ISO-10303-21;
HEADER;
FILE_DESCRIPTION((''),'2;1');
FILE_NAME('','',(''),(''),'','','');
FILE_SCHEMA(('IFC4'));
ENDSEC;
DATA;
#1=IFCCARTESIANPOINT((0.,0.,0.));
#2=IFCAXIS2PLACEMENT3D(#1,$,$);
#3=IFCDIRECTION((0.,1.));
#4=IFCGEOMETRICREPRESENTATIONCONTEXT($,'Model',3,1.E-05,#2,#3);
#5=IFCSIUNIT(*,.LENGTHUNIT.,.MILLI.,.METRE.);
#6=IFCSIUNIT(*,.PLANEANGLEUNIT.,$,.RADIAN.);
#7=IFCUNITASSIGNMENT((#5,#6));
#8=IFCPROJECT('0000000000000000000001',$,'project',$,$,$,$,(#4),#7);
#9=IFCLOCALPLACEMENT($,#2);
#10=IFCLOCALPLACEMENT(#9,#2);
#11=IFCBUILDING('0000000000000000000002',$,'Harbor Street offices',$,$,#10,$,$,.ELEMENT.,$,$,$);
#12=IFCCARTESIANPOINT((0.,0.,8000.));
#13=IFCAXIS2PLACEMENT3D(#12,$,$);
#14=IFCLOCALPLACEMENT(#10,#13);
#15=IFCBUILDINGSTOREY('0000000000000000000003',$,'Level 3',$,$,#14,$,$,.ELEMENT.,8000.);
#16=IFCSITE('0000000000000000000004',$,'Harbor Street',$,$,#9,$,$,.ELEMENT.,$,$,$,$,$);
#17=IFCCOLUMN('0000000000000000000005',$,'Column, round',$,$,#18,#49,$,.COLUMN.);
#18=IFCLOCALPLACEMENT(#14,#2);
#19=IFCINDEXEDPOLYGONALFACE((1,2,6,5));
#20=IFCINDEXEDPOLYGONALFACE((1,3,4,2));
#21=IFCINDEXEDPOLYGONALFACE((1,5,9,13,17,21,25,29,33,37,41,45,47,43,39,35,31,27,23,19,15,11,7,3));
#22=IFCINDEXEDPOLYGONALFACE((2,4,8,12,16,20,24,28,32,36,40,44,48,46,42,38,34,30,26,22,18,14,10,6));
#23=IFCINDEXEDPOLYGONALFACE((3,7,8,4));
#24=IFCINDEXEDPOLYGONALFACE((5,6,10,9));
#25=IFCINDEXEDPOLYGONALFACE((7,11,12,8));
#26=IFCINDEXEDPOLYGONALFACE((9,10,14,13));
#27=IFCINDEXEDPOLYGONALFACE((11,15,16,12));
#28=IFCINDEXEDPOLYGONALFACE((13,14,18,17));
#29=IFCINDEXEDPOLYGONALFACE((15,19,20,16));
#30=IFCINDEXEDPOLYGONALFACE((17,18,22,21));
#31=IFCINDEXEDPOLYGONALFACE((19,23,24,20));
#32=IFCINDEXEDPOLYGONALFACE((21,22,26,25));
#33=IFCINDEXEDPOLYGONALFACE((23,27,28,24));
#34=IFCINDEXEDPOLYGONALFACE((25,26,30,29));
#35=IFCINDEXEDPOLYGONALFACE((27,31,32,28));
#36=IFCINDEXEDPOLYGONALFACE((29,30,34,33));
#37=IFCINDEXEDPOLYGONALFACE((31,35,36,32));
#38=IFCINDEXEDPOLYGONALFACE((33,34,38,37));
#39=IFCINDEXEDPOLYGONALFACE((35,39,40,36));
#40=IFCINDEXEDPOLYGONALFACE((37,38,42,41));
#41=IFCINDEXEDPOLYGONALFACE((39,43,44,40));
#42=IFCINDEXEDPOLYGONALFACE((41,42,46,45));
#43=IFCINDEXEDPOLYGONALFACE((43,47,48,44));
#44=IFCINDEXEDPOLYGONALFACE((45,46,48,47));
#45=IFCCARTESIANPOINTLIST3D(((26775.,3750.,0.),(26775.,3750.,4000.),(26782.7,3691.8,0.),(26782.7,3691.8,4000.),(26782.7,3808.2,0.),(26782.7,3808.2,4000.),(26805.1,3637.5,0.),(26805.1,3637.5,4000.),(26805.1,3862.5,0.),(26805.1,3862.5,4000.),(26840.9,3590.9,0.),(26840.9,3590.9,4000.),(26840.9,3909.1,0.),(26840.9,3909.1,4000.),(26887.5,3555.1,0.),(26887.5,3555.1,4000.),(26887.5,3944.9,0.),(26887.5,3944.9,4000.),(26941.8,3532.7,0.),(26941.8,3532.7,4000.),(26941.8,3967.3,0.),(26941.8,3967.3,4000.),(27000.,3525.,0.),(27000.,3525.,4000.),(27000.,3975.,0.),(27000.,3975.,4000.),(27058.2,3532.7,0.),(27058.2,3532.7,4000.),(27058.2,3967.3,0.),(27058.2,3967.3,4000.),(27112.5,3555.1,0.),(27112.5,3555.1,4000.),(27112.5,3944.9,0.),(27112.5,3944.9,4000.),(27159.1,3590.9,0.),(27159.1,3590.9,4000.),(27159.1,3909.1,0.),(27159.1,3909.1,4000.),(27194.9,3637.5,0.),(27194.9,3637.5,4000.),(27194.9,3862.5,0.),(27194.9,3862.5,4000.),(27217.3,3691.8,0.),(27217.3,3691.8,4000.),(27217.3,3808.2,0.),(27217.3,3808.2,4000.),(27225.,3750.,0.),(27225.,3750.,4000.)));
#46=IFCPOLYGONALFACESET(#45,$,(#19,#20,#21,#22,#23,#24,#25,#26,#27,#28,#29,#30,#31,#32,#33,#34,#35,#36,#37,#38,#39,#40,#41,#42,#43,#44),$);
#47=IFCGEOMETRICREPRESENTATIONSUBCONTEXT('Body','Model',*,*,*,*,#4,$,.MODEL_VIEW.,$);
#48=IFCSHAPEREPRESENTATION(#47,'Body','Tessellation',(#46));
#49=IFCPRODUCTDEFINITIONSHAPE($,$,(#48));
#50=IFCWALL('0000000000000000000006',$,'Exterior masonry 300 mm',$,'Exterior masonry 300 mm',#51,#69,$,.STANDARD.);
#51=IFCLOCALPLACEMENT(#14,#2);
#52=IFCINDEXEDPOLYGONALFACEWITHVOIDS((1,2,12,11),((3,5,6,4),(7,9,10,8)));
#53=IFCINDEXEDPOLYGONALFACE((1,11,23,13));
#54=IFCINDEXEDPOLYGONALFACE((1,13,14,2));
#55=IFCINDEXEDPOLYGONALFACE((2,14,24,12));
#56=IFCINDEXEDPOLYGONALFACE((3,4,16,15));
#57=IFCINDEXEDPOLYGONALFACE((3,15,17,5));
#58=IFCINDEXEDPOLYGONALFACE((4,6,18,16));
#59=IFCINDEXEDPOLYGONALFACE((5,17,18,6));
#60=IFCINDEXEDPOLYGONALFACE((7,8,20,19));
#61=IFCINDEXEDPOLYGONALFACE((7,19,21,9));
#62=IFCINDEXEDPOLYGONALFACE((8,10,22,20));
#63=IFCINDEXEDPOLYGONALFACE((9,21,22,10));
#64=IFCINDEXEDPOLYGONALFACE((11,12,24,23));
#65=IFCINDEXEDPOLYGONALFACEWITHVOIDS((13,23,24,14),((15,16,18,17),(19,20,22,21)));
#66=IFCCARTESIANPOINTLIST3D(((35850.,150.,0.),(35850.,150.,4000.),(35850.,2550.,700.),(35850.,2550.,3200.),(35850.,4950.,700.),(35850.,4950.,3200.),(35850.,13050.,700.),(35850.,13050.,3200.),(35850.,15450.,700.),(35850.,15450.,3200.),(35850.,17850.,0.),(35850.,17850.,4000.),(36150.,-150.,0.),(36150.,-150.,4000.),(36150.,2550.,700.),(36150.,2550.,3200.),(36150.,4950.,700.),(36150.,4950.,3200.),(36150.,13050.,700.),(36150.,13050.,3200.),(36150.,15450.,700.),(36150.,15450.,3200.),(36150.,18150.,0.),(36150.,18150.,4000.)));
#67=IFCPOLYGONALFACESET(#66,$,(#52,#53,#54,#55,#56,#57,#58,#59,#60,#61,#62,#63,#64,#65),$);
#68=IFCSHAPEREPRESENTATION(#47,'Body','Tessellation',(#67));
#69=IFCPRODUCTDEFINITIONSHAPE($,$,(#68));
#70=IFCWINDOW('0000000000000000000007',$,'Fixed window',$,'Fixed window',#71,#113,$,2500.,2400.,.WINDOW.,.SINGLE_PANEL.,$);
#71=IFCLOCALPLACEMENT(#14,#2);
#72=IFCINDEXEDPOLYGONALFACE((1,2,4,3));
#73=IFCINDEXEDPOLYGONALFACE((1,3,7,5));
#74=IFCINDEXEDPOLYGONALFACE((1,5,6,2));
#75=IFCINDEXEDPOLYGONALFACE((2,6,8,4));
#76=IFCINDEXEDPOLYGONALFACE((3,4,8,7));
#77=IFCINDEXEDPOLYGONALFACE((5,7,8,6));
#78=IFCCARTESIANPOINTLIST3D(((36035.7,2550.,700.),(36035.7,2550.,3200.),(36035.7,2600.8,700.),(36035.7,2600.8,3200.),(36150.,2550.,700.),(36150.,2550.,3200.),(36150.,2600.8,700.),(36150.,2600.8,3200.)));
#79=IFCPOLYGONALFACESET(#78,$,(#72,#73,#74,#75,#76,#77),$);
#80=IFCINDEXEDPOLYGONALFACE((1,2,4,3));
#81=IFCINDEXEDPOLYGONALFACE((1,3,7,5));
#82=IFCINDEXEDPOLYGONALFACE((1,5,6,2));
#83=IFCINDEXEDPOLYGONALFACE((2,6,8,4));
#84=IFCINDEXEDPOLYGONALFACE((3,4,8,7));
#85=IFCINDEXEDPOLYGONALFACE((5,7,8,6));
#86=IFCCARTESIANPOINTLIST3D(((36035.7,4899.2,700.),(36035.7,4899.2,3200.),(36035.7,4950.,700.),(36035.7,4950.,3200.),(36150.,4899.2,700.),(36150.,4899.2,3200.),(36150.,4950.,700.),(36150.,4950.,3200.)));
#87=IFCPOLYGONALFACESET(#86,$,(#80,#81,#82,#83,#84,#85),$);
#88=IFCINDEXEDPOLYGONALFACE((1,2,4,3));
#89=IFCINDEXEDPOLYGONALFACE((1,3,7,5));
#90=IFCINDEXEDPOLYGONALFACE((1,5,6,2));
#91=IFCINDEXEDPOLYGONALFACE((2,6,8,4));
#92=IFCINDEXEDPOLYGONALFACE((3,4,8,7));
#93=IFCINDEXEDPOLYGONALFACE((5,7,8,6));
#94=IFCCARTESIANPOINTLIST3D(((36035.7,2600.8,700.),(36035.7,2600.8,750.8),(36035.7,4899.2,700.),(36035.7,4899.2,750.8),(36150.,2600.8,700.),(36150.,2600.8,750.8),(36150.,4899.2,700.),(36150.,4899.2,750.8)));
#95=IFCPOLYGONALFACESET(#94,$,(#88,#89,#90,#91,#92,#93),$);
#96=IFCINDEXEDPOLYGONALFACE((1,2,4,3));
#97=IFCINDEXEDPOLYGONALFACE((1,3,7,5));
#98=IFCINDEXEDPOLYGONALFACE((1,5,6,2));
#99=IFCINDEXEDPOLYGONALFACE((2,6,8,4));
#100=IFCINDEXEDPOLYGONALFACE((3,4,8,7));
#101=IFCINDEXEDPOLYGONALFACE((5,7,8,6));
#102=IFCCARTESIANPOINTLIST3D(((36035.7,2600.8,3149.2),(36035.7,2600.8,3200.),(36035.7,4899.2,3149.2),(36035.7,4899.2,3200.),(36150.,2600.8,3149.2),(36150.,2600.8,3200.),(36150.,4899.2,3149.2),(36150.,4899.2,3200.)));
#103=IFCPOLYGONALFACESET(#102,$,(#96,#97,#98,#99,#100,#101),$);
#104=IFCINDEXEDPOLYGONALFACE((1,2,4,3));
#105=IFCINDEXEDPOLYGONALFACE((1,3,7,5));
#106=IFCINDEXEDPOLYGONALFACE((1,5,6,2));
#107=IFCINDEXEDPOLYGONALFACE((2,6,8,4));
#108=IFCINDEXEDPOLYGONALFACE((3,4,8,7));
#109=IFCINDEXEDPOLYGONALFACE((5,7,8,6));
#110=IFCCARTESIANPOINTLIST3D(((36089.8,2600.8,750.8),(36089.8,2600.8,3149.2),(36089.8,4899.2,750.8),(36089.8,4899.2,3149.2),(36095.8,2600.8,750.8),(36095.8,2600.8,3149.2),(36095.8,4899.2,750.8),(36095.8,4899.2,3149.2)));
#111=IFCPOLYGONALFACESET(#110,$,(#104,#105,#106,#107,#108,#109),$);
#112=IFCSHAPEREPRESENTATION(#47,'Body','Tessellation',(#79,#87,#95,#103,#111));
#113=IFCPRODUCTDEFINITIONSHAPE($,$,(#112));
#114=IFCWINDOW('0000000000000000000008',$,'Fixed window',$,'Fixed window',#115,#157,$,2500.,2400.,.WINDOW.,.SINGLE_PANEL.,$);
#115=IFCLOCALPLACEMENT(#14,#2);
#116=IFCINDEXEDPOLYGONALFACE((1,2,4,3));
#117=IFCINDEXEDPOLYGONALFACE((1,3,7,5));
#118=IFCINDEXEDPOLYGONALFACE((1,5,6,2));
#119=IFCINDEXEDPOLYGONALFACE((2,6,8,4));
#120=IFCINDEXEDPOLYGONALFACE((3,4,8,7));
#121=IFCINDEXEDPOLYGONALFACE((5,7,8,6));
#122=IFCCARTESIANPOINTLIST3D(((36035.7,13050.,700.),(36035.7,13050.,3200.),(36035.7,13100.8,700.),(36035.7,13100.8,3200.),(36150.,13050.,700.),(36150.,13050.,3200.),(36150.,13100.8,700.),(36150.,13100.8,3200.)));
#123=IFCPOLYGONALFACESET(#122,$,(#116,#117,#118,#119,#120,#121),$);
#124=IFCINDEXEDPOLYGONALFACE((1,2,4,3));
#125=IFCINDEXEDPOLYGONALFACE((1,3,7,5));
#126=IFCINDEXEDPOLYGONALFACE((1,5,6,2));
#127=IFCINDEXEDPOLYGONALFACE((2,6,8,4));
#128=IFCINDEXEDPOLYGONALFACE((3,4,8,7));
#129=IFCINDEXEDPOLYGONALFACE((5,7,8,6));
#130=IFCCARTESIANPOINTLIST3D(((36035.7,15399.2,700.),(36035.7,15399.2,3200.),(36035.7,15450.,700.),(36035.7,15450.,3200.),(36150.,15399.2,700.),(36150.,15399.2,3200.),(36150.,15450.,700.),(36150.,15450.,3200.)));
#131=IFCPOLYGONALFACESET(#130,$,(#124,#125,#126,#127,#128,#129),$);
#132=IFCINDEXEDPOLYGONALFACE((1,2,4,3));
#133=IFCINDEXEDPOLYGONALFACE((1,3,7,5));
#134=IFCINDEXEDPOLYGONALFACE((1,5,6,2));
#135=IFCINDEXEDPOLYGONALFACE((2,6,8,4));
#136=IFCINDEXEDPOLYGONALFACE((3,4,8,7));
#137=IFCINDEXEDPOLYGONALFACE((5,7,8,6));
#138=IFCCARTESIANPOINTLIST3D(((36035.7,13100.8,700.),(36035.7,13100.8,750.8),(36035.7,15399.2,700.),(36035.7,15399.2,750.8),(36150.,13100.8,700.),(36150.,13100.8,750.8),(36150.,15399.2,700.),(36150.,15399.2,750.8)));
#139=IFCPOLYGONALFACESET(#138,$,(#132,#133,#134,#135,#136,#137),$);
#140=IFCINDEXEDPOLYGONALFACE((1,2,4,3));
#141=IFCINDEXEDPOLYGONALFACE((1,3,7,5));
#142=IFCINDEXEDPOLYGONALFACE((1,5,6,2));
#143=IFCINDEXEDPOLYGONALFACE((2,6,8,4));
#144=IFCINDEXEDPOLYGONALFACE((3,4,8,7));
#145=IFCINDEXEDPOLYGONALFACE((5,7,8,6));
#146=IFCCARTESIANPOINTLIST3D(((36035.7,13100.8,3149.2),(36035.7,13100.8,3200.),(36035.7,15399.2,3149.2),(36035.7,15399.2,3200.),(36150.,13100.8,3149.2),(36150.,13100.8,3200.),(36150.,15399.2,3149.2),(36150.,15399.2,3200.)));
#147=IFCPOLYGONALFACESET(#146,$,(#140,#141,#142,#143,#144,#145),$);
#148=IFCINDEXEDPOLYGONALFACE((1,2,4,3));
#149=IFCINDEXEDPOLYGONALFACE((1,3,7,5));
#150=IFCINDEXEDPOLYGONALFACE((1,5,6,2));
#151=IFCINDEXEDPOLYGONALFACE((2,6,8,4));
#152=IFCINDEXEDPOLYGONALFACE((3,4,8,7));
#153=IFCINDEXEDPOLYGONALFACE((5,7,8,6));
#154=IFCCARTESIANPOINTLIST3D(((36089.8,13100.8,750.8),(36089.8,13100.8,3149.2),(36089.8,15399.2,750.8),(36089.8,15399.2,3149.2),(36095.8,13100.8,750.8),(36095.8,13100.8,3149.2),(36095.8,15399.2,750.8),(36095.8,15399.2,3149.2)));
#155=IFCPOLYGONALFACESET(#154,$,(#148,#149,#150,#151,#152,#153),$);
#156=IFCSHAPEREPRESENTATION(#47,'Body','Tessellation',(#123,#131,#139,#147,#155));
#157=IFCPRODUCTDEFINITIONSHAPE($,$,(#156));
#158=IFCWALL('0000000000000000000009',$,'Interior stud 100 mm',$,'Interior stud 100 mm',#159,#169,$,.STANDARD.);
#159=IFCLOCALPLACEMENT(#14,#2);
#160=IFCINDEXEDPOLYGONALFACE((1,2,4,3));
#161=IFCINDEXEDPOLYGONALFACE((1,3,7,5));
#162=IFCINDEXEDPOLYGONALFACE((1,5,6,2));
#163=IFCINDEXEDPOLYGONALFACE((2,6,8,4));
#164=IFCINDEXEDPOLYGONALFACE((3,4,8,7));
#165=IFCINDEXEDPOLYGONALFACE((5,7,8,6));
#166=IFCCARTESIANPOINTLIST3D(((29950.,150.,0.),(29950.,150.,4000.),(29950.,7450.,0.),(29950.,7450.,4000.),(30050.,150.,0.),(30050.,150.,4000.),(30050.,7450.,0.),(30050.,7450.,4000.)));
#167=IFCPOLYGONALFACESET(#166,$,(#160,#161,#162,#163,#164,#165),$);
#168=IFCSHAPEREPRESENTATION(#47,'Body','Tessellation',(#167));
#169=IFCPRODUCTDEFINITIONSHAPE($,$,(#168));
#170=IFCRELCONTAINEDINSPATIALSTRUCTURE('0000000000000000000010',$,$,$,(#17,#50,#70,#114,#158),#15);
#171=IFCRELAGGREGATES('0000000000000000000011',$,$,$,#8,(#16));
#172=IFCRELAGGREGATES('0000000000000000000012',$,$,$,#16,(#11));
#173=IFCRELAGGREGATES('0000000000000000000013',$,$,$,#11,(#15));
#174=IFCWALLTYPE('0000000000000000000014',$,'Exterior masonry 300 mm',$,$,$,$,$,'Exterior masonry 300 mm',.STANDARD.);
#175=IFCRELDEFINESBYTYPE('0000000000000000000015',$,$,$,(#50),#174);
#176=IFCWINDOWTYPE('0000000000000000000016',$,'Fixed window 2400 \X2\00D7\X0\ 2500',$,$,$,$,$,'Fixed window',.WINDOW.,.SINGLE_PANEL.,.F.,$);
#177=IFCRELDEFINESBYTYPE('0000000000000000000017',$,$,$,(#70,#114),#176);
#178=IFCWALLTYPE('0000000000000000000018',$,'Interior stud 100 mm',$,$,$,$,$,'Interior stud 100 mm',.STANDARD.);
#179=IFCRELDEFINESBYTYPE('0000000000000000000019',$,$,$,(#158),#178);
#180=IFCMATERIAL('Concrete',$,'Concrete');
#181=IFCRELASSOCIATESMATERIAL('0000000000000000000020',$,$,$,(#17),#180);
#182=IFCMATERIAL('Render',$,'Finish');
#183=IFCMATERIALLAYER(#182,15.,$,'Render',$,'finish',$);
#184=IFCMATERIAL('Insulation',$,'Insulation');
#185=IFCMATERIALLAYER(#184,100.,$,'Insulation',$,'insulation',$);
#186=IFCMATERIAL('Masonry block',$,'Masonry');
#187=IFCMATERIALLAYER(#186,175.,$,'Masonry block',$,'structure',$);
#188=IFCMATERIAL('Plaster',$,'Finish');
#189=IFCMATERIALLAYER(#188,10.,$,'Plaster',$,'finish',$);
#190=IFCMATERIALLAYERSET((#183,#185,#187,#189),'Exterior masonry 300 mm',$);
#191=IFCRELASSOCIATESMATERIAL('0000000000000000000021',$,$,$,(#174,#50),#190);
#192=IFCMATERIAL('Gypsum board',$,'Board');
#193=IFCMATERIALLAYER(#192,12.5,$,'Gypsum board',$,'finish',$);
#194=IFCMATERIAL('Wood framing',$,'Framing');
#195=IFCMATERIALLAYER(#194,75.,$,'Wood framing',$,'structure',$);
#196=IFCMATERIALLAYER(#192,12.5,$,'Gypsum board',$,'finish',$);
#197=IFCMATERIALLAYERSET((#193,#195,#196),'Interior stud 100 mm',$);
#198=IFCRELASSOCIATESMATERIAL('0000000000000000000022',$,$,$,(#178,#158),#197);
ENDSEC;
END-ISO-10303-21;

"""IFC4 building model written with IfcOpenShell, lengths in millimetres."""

from ifc_helpers import new_model, si_unit, direction, frame, origin, origin_with_axes, origin_2d, place, context, subcontext, project, spatial, polyline, circle, outline, extrude, material, layer, layer_set, layer_usage, type_object, element, fill, save


model = new_model("IFC4")

# Units and contexts
model_context = context("Model", 3, precision=1e-05, world=origin(), true_north=direction((0.0, 1.0)))
body_context = subcontext(model_context, "Body", "Model", "MODEL_VIEW")
ifc_project = project(units=[si_unit("LENGTHUNIT", "METRE", prefix="MILLI"), si_unit("PLANEANGLEUNIT", "RADIAN")], contexts=[model_context])

# Site, building, storey
site_placement = place(None, origin())
site = spatial("IfcSite", under=ifc_project, at=site_placement, Name="Harbor Street", CompositionType="ELEMENT")
building_placement = place(site_placement, origin())
building = spatial("IfcBuilding", under=site, at=building_placement, Name="Harbor Street offices", CompositionType="ELEMENT")
storey_placement = place(building_placement, frame((0.0, 0.0, 8000.0)))
storey = spatial("IfcBuildingStorey", under=building, at=storey_placement, Name="Level 3", CompositionType="ELEMENT", Elevation=8000.0)

# Column
ifc_material_1 = material(Name="Concrete", Category="Concrete")
column_placement = place(storey_placement, frame((27000.0, 3750.0, 0.0), z_axis=(0.0, 0.0, 1.0), x_axis=(1.0, 0.0, 0.0)))
element("IfcColumn", 1, at=column_placement, inside=storey, material=ifc_material_1, Name="Column, round", PredefinedType="COLUMN", context=body_context, shape_type="SweptSolid", body=[
    extrude(circle(Radius=225.0, at=origin_2d()), origin(), (0.0, 0.0, 1.0), 4000.0),
])

# Wall, openings, windows
ifc_material_2 = material(Name="Render", Category="Finish")
ifc_layer_1 = layer(ifc_material_2, 15.0, Name="Render", Category="finish")
ifc_material_3 = material(Name="Insulation", Category="Insulation")
ifc_layer_2 = layer(ifc_material_3, 100.0, Name="Insulation", Category="insulation")
ifc_material_4 = material(Name="Masonry block", Category="Masonry")
ifc_layer_3 = layer(ifc_material_4, 175.0, Name="Masonry block", Category="structure")
ifc_material_5 = material(Name="Plaster", Category="Finish")
ifc_layer_4 = layer(ifc_material_5, 10.0, Name="Plaster", Category="finish")
ifc_layer_set_1 = layer_set([ifc_layer_1, ifc_layer_2, ifc_layer_3, ifc_layer_4], Name="Exterior masonry 300 mm")
ifc_layer_usage_1 = layer_usage(ifc_layer_set_1, "AXIS2", "POSITIVE", -150.0)
wall_type_1 = type_object("IfcWallType", Name="Exterior masonry 300 mm", ElementType="Exterior masonry 300 mm", PredefinedType="STANDARD", material=ifc_layer_set_1)
wall_1_placement = place(storey_placement, frame((36000.0, 0.0, 0.0), z_axis=(0.0, 0.0, 1.0), x_axis=(0.0, 1.0, 0.0)))
wall_1 = element("IfcWall", 2, at=wall_1_placement, inside=storey, type_object=wall_type_1, material=ifc_layer_usage_1, Name="Exterior masonry 300 mm", ObjectType="Exterior masonry 300 mm", PredefinedType="STANDARD", context=body_context, shape_type="SweptSolid", body=[
    extrude(outline(polyline([(-150.0, -150.0), (18150.0, -150.0), (17850.0, 150.0), (150.0, 150.0), (-150.0, -150.0)])), origin(), (0.0, 0.0, 1.0), 4000.0),
])
opening_1_placement = place(wall_1_placement, frame((2550.0, 0.0, 700.0), z_axis=(0.0, 0.0, 1.0), x_axis=(1.0, 0.0, 0.0)))
opening_1 = element("IfcOpeningElement", 3, at=opening_1_placement, cuts=wall_1, PredefinedType="OPENING", context=body_context, shape_type="SweptSolid", body=[
    extrude(outline(polyline([(0.0, -160.0), (2400.0, -160.0), (2400.0, 160.0), (0.0, 160.0), (0.0, -160.0)])), origin(), (0.0, 0.0, 1.0), 2500.0),
])
opening_2_placement = place(wall_1_placement, frame((13050.0, 0.0, 700.0), z_axis=(0.0, 0.0, 1.0), x_axis=(1.0, 0.0, 0.0)))
opening_2 = element("IfcOpeningElement", 4, at=opening_2_placement, cuts=wall_1, PredefinedType="OPENING", context=body_context, shape_type="SweptSolid", body=[
    extrude(outline(polyline([(0.0, -160.0), (2400.0, -160.0), (2400.0, 160.0), (0.0, 160.0), (0.0, -160.0)])), origin(), (0.0, 0.0, 1.0), 2500.0),
])
window_type = type_object("IfcWindowType", Name="Fixed window 2400 × 2500", ElementType="Fixed window", ParameterTakesPrecedence=False, PartitioningType="SINGLE_PANEL", PredefinedType="WINDOW")
window_1_placement = place(opening_1_placement, origin_with_axes())
window_1 = element("IfcWindow", 5, at=window_1_placement, inside=storey, type_object=window_type, Name="Fixed window", ObjectType="Fixed window", OverallHeight=2500.0, OverallWidth=2400.0, PartitioningType="SINGLE_PANEL", PredefinedType="WINDOW", context=body_context, shape_type="SweptSolid", body=[
    extrude(outline(polyline([(0.0, -150.0), (50.8, -150.0), (50.8, -35.7), (0.0, -35.7), (0.0, -150.0)])), origin(), (0.0, 0.0, 1.0), 2500.0),
    extrude(outline(polyline([(2349.2, -150.0), (2400.0, -150.0), (2400.0, -35.7), (2349.2, -35.7), (2349.2, -150.0)])), origin(), (0.0, 0.0, 1.0), 2500.0),
    extrude(outline(polyline([(50.8, -150.0), (2349.2, -150.0), (2349.2, -35.7), (50.8, -35.7), (50.8, -150.0)])), origin(), (0.0, 0.0, 1.0), 50.8),
    extrude(outline(polyline([(50.8, -150.0), (2349.2, -150.0), (2349.2, -35.7), (50.8, -35.7), (50.8, -150.0)])), frame((0.0, 0.0, 2449.2)), (0.0, 0.0, 1.0), 50.8),
    extrude(outline(polyline([(50.8, -95.8), (2349.2, -95.8), (2349.2, -89.8), (50.8, -89.8), (50.8, -95.8)])), frame((0.0, 0.0, 50.8)), (0.0, 0.0, 1.0), 2398.4),
])
fill(opening_1, window_1)
window_2_placement = place(opening_2_placement, origin_with_axes())
window_2 = element("IfcWindow", 6, at=window_2_placement, inside=storey, type_object=window_type, Name="Fixed window", ObjectType="Fixed window", OverallHeight=2500.0, OverallWidth=2400.0, PartitioningType="SINGLE_PANEL", PredefinedType="WINDOW", context=body_context, shape_type="SweptSolid", body=[
    extrude(outline(polyline([(0.0, -150.0), (50.8, -150.0), (50.8, -35.7), (0.0, -35.7), (0.0, -150.0)])), origin(), (0.0, 0.0, 1.0), 2500.0),
    extrude(outline(polyline([(2349.2, -150.0), (2400.0, -150.0), (2400.0, -35.7), (2349.2, -35.7), (2349.2, -150.0)])), origin(), (0.0, 0.0, 1.0), 2500.0),
    extrude(outline(polyline([(50.8, -150.0), (2349.2, -150.0), (2349.2, -35.7), (50.8, -35.7), (50.8, -150.0)])), origin(), (0.0, 0.0, 1.0), 50.8),
    extrude(outline(polyline([(50.8, -150.0), (2349.2, -150.0), (2349.2, -35.7), (50.8, -35.7), (50.8, -150.0)])), frame((0.0, 0.0, 2449.2)), (0.0, 0.0, 1.0), 50.8),
    extrude(outline(polyline([(50.8, -95.8), (2349.2, -95.8), (2349.2, -89.8), (50.8, -89.8), (50.8, -95.8)])), frame((0.0, 0.0, 50.8)), (0.0, 0.0, 1.0), 2398.4),
])
fill(opening_2, window_2)

# Wall
ifc_material_6 = material(Name="Gypsum board", Category="Board")
ifc_layer_5 = layer(ifc_material_6, 12.5, Name="Gypsum board", Category="finish")
ifc_material_7 = material(Name="Wood framing", Category="Framing")
ifc_layer_6 = layer(ifc_material_7, 75.0, Name="Wood framing", Category="structure")
ifc_layer_7 = layer(ifc_material_6, 12.5, Name="Gypsum board", Category="finish")
ifc_layer_set_2 = layer_set([ifc_layer_5, ifc_layer_6, ifc_layer_7], Name="Interior stud 100 mm")
ifc_layer_usage_2 = layer_usage(ifc_layer_set_2, "AXIS2", "NEGATIVE", 50.0)
wall_type_2 = type_object("IfcWallType", Name="Interior stud 100 mm", ElementType="Interior stud 100 mm", PredefinedType="STANDARD", material=ifc_layer_set_2)
wall_2_placement = place(storey_placement, frame((30000.0, 0.0, 0.0), z_axis=(0.0, 0.0, 1.0), x_axis=(0.0, 1.0, 0.0)))
element("IfcWall", 7, at=wall_2_placement, inside=storey, type_object=wall_type_2, material=ifc_layer_usage_2, Name="Interior stud 100 mm", ObjectType="Interior stud 100 mm", PredefinedType="STANDARD", context=body_context, shape_type="SweptSolid", body=[
    extrude(outline(polyline([(150.0, -50.0), (7450.0, -50.0), (7450.0, 50.0), (150.0, 50.0), (150.0, -50.0)])), origin(), (0.0, 0.0, 1.0), 4000.0),
])

save(model, "model.ifc")
